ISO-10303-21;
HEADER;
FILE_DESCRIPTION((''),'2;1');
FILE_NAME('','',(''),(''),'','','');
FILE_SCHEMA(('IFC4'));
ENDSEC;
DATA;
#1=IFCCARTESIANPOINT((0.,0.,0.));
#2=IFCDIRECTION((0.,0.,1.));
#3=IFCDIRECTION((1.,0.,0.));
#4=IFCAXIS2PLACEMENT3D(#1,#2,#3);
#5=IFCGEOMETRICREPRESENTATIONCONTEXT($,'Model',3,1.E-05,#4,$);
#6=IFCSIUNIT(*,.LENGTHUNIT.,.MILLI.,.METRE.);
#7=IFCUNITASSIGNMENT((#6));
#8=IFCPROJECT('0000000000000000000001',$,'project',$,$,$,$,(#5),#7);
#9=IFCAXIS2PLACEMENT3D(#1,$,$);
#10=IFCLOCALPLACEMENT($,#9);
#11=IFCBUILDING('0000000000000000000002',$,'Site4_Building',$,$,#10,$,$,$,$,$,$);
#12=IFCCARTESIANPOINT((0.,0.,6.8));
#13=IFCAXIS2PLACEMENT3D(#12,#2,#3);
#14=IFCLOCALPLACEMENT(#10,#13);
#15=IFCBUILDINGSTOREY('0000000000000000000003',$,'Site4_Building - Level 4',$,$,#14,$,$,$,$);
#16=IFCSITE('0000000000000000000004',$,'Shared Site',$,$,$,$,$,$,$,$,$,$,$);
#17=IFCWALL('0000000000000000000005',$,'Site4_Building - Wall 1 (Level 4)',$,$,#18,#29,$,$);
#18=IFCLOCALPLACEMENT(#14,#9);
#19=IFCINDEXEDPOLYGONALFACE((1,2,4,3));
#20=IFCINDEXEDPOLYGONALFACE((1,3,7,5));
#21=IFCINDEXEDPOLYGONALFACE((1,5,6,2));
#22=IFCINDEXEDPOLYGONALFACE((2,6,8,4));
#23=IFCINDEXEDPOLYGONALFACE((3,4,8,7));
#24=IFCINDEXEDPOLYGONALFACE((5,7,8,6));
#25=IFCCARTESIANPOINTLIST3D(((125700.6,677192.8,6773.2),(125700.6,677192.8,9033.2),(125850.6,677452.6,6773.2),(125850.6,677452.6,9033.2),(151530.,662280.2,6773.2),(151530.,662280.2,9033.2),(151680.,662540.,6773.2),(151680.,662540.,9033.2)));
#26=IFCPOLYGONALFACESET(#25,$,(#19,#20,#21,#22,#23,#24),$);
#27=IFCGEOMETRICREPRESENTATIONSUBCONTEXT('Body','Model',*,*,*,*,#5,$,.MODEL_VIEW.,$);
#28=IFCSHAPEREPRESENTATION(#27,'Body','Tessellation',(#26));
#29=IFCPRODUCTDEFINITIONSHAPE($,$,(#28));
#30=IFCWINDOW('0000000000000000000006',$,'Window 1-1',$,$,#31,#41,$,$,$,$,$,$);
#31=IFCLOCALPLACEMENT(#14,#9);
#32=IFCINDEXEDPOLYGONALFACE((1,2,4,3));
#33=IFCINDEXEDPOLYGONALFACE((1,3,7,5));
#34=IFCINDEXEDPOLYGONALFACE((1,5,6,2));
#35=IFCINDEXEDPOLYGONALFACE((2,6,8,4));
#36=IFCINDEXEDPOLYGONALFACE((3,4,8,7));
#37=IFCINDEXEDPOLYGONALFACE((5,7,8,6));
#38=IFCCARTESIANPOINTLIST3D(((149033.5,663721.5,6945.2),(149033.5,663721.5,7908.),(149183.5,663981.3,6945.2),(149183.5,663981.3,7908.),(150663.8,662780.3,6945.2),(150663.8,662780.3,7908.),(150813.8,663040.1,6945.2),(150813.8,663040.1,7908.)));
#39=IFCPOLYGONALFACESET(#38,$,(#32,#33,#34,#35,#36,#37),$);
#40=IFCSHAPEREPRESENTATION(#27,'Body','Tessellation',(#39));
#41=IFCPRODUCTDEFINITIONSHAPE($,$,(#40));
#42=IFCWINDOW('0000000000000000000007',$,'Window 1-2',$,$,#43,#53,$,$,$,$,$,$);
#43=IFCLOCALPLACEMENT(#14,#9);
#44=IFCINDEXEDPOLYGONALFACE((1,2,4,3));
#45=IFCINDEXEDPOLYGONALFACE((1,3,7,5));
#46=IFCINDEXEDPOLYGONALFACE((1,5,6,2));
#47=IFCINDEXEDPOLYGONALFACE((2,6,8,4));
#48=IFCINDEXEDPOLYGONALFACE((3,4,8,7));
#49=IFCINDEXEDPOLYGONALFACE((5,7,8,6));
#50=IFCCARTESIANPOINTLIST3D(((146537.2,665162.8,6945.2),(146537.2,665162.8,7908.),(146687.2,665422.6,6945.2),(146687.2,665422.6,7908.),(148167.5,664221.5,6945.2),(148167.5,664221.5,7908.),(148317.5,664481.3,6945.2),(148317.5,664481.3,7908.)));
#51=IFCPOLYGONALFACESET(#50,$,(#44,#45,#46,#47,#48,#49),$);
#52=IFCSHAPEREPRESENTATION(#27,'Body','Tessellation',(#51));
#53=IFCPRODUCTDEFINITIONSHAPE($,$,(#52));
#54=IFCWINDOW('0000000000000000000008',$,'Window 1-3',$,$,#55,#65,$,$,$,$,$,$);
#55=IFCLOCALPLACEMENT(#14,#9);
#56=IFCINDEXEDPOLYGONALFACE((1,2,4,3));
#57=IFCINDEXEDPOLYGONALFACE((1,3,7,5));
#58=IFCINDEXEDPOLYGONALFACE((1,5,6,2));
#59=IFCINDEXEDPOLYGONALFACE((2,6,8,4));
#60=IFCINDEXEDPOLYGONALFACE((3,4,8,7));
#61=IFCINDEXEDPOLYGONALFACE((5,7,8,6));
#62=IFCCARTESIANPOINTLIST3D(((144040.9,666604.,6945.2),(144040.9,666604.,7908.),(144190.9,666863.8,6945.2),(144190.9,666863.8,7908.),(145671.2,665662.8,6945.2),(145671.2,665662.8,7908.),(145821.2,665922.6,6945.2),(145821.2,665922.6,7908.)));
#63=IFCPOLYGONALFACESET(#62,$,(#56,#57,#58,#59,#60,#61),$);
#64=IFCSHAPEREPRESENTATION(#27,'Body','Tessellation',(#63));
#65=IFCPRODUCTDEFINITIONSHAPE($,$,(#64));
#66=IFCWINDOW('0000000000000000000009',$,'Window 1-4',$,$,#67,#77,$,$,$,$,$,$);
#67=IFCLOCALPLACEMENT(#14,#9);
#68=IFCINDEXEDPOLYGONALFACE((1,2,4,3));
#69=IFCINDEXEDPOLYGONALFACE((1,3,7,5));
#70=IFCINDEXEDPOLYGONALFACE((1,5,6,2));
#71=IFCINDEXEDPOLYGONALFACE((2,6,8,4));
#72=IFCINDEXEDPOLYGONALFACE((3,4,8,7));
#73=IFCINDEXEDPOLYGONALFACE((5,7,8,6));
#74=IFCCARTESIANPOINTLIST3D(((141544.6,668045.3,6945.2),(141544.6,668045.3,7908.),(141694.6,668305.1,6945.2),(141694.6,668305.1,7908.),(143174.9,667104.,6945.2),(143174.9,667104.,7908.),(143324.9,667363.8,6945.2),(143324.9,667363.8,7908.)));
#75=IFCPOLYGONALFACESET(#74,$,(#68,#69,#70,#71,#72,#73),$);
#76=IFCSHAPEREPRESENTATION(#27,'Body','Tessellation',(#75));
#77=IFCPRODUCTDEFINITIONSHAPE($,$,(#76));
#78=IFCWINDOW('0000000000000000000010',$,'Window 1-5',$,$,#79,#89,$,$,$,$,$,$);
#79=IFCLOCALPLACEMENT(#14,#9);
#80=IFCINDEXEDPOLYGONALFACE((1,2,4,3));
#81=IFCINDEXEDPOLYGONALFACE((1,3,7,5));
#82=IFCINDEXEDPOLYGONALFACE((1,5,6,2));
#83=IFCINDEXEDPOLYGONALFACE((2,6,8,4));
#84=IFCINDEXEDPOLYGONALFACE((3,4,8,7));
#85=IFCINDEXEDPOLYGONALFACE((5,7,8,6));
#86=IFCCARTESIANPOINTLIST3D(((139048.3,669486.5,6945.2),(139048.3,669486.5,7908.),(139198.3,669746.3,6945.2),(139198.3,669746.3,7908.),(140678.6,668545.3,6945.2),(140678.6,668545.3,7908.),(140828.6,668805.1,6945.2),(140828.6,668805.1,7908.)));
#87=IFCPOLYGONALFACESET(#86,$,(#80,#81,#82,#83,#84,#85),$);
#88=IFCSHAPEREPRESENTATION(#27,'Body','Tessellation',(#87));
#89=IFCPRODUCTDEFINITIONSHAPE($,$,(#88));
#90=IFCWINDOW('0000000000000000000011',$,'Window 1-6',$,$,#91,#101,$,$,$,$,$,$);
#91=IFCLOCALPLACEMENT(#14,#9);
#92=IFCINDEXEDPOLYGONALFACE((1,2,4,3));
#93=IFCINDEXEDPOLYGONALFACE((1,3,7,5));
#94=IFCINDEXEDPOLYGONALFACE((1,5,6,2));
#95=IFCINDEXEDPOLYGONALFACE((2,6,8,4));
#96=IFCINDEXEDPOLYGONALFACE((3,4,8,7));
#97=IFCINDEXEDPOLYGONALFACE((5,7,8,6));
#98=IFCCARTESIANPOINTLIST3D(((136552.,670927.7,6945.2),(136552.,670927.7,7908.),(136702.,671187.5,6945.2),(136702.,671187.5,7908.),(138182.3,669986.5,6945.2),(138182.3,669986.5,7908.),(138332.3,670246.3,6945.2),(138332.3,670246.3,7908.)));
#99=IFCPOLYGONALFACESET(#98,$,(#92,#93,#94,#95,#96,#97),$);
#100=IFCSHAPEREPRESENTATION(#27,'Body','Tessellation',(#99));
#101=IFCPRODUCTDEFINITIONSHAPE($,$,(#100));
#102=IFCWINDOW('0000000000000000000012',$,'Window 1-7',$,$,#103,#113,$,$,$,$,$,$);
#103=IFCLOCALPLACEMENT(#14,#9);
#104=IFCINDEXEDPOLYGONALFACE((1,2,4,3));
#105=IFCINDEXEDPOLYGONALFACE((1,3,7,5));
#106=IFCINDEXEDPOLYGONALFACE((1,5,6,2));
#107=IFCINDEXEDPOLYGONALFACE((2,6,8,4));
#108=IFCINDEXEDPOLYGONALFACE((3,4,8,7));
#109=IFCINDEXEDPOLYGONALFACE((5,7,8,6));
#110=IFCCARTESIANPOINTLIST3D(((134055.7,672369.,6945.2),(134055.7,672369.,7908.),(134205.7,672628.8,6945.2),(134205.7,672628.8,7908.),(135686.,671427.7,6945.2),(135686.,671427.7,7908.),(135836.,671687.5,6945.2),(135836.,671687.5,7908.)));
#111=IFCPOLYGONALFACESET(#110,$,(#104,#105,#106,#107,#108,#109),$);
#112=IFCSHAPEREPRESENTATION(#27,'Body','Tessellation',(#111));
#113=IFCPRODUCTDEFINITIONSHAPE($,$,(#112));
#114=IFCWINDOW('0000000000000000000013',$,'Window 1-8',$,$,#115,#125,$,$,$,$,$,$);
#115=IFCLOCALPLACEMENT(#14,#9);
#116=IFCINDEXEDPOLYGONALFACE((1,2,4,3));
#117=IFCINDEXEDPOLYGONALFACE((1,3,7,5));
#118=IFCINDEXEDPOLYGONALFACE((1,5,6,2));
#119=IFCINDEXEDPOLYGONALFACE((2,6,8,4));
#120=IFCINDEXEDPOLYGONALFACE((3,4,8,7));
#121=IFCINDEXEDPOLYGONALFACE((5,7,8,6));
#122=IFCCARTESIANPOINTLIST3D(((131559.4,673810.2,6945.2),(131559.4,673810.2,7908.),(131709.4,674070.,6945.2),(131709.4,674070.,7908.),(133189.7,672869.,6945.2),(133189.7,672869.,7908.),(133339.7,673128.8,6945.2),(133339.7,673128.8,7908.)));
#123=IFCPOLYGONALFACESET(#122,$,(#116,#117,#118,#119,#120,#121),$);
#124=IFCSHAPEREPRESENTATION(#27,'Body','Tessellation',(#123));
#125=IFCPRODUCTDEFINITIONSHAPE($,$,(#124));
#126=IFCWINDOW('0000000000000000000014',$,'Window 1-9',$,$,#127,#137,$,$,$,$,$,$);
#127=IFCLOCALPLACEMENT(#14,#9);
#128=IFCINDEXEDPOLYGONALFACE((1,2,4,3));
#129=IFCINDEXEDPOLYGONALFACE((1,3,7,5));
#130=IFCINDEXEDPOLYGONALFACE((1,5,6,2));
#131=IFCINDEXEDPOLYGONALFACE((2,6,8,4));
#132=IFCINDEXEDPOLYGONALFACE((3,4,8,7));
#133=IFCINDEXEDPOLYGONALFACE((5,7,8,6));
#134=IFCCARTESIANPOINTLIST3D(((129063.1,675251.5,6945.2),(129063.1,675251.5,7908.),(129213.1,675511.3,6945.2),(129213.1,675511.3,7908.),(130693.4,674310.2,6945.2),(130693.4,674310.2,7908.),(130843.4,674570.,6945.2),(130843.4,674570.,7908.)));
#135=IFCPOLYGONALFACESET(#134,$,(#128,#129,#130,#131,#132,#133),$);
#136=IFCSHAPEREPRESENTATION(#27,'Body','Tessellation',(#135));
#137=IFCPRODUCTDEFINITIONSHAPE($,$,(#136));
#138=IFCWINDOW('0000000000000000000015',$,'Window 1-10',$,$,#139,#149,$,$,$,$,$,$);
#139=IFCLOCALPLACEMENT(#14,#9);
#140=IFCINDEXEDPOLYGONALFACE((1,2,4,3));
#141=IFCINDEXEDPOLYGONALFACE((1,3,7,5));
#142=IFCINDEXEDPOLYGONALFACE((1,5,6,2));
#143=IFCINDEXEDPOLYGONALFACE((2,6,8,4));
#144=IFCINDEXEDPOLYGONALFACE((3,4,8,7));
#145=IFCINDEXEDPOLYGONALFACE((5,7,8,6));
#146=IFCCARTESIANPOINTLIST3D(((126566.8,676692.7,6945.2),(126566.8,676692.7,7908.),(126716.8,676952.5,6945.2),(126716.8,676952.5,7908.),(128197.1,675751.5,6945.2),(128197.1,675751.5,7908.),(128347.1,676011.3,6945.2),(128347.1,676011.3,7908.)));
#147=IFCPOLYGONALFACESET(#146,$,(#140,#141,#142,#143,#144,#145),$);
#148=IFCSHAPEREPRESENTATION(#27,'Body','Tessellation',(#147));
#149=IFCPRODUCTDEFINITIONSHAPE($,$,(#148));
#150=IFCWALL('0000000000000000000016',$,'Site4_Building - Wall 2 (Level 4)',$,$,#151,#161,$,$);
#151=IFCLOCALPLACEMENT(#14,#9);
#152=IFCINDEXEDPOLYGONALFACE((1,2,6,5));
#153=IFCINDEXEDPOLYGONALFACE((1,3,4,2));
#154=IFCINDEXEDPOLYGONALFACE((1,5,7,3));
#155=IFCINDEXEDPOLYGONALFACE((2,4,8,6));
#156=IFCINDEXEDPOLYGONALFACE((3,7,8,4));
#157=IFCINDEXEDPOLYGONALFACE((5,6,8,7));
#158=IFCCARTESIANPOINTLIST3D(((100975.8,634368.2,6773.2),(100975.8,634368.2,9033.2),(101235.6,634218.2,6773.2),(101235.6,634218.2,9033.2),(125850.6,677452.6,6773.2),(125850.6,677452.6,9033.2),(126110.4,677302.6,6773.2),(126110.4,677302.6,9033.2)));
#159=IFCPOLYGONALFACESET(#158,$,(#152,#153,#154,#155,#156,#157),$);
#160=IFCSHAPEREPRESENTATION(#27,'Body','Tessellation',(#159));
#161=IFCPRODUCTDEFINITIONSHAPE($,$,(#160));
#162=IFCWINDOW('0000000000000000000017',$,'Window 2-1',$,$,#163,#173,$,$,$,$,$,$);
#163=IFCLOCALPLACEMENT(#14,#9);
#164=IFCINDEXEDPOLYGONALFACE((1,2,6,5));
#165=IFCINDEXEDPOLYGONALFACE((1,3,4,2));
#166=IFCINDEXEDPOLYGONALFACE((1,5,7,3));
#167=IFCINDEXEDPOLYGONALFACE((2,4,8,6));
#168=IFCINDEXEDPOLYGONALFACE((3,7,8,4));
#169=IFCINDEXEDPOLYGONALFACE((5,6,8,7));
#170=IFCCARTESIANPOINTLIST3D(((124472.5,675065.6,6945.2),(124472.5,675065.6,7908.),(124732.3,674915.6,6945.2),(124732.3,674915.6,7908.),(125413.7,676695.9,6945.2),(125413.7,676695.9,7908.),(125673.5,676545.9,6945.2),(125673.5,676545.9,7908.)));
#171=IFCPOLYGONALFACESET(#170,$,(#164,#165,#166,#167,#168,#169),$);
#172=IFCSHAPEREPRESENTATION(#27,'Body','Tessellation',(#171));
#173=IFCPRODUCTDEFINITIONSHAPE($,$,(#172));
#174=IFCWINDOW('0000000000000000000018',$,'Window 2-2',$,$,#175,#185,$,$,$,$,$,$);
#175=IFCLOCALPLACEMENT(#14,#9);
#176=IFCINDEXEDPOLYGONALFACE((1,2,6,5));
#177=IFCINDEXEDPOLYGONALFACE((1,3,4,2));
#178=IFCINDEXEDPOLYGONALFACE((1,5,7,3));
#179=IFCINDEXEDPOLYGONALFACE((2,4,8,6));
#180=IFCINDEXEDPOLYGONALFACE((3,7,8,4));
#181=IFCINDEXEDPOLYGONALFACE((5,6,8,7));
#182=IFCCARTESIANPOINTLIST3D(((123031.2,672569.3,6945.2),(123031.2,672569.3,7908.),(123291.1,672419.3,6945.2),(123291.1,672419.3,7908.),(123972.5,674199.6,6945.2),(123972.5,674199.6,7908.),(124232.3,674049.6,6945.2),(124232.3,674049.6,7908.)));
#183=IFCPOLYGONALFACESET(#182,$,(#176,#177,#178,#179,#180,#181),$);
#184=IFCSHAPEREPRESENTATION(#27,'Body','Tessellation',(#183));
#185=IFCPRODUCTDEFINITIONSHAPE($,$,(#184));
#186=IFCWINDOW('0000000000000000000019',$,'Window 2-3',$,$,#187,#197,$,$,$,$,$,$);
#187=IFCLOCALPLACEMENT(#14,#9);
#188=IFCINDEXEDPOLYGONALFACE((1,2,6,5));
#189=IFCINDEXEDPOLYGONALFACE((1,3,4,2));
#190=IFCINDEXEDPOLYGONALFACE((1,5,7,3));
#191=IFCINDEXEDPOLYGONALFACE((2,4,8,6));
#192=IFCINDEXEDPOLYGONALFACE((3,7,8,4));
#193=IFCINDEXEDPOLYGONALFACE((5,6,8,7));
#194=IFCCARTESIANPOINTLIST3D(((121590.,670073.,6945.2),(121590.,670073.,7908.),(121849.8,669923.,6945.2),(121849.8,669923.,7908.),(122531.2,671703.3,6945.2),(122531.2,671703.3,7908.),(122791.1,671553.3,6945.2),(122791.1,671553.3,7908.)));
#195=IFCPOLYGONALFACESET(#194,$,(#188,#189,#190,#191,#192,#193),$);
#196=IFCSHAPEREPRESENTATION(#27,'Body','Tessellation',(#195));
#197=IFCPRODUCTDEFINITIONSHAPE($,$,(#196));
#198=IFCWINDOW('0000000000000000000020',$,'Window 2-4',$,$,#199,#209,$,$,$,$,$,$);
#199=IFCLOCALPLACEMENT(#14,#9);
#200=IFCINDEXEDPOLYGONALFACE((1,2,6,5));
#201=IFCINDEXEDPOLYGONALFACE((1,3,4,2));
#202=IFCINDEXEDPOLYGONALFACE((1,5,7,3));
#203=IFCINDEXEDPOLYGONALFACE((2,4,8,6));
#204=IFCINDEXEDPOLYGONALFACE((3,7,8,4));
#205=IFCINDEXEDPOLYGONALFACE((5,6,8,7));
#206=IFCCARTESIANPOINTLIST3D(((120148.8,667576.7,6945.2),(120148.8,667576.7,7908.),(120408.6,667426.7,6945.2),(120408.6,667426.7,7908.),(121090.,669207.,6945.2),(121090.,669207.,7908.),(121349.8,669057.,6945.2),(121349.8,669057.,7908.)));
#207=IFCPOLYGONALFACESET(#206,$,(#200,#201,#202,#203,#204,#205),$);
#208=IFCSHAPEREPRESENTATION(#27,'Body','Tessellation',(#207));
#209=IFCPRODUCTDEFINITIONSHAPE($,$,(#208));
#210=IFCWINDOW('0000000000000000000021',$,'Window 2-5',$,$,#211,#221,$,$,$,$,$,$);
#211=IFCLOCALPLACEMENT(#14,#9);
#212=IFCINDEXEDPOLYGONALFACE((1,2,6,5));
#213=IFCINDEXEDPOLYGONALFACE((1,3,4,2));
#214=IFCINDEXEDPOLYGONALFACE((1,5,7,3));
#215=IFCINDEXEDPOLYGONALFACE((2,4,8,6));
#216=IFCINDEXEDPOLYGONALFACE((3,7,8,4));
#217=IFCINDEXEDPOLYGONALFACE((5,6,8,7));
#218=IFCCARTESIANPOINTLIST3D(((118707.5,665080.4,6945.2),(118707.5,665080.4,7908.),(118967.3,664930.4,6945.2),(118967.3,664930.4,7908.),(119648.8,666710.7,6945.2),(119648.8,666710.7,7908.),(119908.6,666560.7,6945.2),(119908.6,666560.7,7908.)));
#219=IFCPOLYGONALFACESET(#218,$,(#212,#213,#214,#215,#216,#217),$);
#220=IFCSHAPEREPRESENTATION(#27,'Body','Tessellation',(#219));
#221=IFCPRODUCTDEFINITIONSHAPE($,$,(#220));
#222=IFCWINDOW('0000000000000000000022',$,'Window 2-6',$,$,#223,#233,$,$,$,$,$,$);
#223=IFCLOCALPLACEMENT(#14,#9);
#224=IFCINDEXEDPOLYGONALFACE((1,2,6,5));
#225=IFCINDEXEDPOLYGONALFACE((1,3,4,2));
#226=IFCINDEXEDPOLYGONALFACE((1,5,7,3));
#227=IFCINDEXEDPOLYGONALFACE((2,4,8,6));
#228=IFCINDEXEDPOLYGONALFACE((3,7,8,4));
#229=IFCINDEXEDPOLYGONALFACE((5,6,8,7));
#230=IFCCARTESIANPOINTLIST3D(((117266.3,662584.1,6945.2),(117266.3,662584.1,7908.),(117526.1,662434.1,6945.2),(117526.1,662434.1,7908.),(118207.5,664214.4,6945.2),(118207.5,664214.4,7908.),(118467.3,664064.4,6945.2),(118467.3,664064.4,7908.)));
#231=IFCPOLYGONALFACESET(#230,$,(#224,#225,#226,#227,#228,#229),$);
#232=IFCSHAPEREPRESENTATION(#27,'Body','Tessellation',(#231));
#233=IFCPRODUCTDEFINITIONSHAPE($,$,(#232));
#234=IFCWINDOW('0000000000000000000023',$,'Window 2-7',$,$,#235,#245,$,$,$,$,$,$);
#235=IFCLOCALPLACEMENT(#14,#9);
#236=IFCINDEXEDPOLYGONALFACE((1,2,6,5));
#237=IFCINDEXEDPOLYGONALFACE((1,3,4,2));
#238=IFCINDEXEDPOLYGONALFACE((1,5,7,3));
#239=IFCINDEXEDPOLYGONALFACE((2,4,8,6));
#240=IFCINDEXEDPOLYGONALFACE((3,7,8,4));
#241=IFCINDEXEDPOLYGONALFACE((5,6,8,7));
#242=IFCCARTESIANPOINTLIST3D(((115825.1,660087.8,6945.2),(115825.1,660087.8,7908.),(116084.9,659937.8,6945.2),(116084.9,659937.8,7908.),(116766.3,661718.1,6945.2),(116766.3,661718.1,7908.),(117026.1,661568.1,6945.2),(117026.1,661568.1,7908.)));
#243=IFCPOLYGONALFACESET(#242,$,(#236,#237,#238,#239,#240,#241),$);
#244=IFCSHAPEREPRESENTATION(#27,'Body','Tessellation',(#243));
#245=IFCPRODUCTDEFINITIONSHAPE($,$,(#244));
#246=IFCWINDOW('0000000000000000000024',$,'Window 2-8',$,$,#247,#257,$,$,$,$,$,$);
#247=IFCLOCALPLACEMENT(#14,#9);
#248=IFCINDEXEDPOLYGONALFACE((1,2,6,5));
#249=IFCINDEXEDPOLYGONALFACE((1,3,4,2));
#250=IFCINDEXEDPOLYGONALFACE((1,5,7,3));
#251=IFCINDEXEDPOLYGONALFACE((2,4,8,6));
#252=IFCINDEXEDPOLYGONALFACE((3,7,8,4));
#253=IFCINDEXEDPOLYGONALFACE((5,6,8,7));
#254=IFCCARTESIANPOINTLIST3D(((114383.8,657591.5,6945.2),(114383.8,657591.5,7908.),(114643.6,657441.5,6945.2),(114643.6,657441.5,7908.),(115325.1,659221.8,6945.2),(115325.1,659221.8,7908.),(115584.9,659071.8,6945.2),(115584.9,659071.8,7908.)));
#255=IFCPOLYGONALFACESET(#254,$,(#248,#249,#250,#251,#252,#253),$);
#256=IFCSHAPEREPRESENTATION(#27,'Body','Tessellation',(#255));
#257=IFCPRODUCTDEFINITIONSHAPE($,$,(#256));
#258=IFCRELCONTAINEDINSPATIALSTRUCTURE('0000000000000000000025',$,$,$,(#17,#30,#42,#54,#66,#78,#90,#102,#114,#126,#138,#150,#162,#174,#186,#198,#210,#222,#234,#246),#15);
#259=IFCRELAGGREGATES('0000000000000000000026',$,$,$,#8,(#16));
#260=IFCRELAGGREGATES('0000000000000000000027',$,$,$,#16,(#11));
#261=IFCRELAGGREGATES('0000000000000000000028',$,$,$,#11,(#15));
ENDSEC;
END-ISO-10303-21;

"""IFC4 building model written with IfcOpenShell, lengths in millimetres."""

from ifc_helpers import new_model, si_unit, frame, origin, origin_with_axes, place, context, subcontext, project, spatial, indexed_curve, outline, extrude, element, save


model = new_model("IFC4")

# Units and contexts
model_context = context("Model", 3, precision=1e-05, world=origin_with_axes())
body_context = subcontext(model_context, "Body", "Model", "MODEL_VIEW")
ifc_project = project(units=[si_unit("LENGTHUNIT", "METRE", prefix="MILLI")], contexts=[model_context])

# Site, building, storey
site = spatial("IfcSite", under=ifc_project, Name="Shared Site")
building_placement = place(None, origin())
building = spatial("IfcBuilding", under=site, at=building_placement, Name="Site4_Building")
storey_placement = place(building_placement, frame((0.0, 0.0, 6.8), z_axis=(0.0, 0.0, 1.0), x_axis=(1.0, 0.0, 0.0)))
storey = spatial("IfcBuildingStorey", under=building, at=storey_placement, Name="Site4_Building - Level 4")

# Wall
wall_1_placement = place(storey_placement, frame((151680.0, 662540.0, 6773.2), z_axis=(0.0, 0.0, 1.0), x_axis=(-0.866025, 0.5, 0.0)))
element("IfcWall", 1, at=wall_1_placement, inside=storey, Name="Site4_Building - Wall 1 (Level 4)", context=body_context, shape_type="SweptSolid", body=[
    extrude(outline(indexed_curve([(0.0, 0.0), (0.0, 300.0), (29825.2, 300.0), (29825.2, 0.0), (0.0, 0.0)], self_intersect=False)), origin_with_axes(), (0.0, 0.0, 1.0), 2260.0),
])

# Windows
for number, where, z_axis, x_axis, name in (
    (2, (150813.8, 663040.1, 6945.2), (0.0, 0.0, 1.0), (-0.866025, 0.5, 0.0), "Window 1-1"),
    (3, (148317.5, 664481.3, 6945.2), (0.0, 0.0, 1.0), (-0.866025, 0.5, 0.0), "Window 1-2"),
    (4, (145821.2, 665922.6, 6945.2), (0.0, 0.0, 1.0), (-0.866025, 0.5, 0.0), "Window 1-3"),
    (5, (143324.9, 667363.8, 6945.2), (0.0, 0.0, 1.0), (-0.866025, 0.5, 0.0), "Window 1-4"),
    (6, (140828.6, 668805.1, 6945.2), (0.0, 0.0, 1.0), (-0.866025, 0.5, 0.0), "Window 1-5"),
    (7, (138332.3, 670246.3, 6945.2), (0.0, 0.0, 1.0), (-0.866025, 0.5, 0.0), "Window 1-6"),
    (8, (135836.0, 671687.5, 6945.2), (0.0, 0.0, 1.0), (-0.866025, 0.5, 0.0), "Window 1-7"),
    (9, (133339.7, 673128.8, 6945.2), (0.0, 0.0, 1.0), (-0.866025, 0.5, 0.0), "Window 1-8"),
    (10, (130843.4, 674570.0, 6945.2), (0.0, 0.0, 1.0), (-0.866025, 0.5, 0.0), "Window 1-9"),
    (11, (128347.1, 676011.3, 6945.2), (0.0, 0.0, 1.0), (-0.866025, 0.5, 0.0), "Window 1-10"),
):
    element("IfcWindow", number, at=place(storey_placement, frame(where, z_axis=z_axis, x_axis=x_axis)), inside=storey, Name=name, context=body_context, shape_type="SweptSolid", body=[
        extrude(outline(indexed_curve([(0.0, 0.0), (0.0, 300.0), (1882.5, 300.0), (1882.5, 0.0), (0.0, 0.0)], self_intersect=False)), origin_with_axes(), (0.0, 0.0, 1.0), 962.8),
    ])

# Wall
wall_2_placement = place(storey_placement, frame((125850.6, 677452.6, 6773.2), z_axis=(0.0, 0.0, 1.0), x_axis=(-0.5, -0.866025, 0.0)))
element("IfcWall", 12, at=wall_2_placement, inside=storey, Name="Site4_Building - Wall 2 (Level 4)", context=body_context, shape_type="SweptSolid", body=[
    extrude(outline(indexed_curve([(0.0, 0.0), (0.0, 300.0), (49749.6, 300.0), (49749.6, 0.0), (0.0, 0.0)], self_intersect=False)), origin_with_axes(), (0.0, 0.0, 1.0), 2260.0),
])

# Windows
for number, where, z_axis, x_axis, name in (
    (13, (125413.7, 676695.9, 6945.2), (0.0, 0.0, 1.0), (-0.5, -0.866025, 0.0), "Window 2-1"),
    (14, (123972.5, 674199.6, 6945.2), (0.0, 0.0, 1.0), (-0.5, -0.866025, 0.0), "Window 2-2"),
    (15, (122531.2, 671703.3, 6945.2), (0.0, 0.0, 1.0), (-0.5, -0.866025, 0.0), "Window 2-3"),
    (16, (121090.0, 669207.0, 6945.2), (0.0, 0.0, 1.0), (-0.5, -0.866025, 0.0), "Window 2-4"),
    (17, (119648.8, 666710.7, 6945.2), (0.0, 0.0, 1.0), (-0.5, -0.866025, 0.0), "Window 2-5"),
    (18, (118207.5, 664214.4, 6945.2), (0.0, 0.0, 1.0), (-0.5, -0.866025, 0.0), "Window 2-6"),
    (19, (116766.3, 661718.1, 6945.2), (0.0, 0.0, 1.0), (-0.5, -0.866025, 0.0), "Window 2-7"),
    (20, (115325.1, 659221.8, 6945.2), (0.0, 0.0, 1.0), (-0.5, -0.866025, 0.0), "Window 2-8"),
):
    element("IfcWindow", number, at=place(storey_placement, frame(where, z_axis=z_axis, x_axis=x_axis)), inside=storey, Name=name, context=body_context, shape_type="SweptSolid", body=[
        extrude(outline(indexed_curve([(0.0, 0.0), (0.0, 300.0), (1882.5, 300.0), (1882.5, 0.0), (0.0, 0.0)], self_intersect=False)), origin_with_axes(), (0.0, 0.0, 1.0), 962.8),
    ])

save(model, "model.ifc")
